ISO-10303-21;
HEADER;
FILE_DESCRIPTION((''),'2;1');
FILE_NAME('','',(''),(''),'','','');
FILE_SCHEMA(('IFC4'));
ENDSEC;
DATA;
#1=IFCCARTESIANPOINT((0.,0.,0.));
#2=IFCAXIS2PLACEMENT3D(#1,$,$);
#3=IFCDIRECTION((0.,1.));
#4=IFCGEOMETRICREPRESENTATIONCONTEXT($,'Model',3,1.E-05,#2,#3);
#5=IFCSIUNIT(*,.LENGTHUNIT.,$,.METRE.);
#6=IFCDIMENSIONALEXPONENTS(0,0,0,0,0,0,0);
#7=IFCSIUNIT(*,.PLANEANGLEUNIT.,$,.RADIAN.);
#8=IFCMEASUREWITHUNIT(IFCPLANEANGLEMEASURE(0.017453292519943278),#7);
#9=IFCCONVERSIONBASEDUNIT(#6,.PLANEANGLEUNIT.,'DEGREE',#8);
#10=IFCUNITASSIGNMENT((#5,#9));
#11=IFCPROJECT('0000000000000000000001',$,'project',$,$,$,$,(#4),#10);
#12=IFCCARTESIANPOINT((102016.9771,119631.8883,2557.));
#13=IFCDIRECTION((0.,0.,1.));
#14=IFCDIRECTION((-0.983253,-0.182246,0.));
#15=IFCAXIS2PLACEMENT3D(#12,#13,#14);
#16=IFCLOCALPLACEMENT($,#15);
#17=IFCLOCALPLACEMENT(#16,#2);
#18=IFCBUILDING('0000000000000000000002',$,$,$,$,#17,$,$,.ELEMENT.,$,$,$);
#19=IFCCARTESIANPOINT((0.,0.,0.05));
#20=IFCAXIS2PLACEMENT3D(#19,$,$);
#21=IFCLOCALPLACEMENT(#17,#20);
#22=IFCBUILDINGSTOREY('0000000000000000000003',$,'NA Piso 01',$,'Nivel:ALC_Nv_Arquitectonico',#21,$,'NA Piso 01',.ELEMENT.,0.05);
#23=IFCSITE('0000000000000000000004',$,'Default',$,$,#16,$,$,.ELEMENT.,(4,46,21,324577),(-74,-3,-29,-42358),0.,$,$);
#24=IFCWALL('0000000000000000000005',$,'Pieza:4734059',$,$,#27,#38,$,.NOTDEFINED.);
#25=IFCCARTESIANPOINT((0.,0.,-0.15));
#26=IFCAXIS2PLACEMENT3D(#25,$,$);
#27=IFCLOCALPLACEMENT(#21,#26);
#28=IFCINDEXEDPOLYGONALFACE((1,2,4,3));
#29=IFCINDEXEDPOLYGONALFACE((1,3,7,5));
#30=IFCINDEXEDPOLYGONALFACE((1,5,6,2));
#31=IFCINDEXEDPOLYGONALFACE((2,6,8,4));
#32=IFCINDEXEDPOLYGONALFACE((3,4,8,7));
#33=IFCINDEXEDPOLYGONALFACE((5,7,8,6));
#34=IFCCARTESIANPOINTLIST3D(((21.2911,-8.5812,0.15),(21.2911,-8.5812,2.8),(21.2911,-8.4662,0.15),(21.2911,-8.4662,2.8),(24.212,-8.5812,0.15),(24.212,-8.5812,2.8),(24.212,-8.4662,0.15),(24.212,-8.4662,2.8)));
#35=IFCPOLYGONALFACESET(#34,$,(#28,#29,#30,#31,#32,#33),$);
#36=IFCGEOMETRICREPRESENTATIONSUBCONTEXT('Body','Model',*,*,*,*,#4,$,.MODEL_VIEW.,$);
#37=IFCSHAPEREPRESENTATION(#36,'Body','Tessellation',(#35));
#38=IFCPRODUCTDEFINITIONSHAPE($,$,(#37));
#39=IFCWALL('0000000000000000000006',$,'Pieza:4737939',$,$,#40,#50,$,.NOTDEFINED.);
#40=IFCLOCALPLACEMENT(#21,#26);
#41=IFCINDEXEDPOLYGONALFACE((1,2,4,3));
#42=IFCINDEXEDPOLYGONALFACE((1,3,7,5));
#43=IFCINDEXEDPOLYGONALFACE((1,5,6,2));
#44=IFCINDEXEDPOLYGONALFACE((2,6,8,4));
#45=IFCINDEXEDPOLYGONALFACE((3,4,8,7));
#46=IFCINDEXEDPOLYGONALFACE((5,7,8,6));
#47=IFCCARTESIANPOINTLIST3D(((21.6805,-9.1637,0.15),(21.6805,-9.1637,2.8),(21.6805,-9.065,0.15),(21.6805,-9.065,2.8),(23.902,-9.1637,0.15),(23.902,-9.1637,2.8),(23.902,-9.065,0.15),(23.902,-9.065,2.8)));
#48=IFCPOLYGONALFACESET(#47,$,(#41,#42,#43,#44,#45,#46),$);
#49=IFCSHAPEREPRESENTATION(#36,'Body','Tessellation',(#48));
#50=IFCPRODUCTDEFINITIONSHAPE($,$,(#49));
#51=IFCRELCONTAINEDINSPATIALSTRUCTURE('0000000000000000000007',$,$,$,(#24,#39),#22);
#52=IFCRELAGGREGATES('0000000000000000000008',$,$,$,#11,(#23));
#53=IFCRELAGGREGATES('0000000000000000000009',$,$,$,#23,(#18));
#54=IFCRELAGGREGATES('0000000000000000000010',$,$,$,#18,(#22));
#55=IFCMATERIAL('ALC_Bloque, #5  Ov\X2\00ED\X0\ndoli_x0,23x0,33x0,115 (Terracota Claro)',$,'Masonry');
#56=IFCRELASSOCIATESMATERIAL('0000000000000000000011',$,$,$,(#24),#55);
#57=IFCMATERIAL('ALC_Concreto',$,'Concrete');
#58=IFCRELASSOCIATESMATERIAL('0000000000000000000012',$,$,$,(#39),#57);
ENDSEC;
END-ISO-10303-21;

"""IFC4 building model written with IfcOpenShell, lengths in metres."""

from ifc_helpers import new_model, entity, si_unit, converted_unit, direction, frame, frame_2d, origin, origin_2d_with_axis, place, context, subcontext, project, spatial, rectangle, extrude, material, element, save


model = new_model("IFC4")

# Units and contexts
model_context = context("Model", 3, precision=1e-05, world=origin(), true_north=direction((0.0, 1.0)))
body_context = subcontext(model_context, "Body", "Model", "MODEL_VIEW")
ifc_project = project(units=[si_unit("LENGTHUNIT", "METRE"), converted_unit("PLANEANGLEUNIT", "DEGREE", entity("IfcPlaneAngleMeasure", 0.017453292519943278), si_unit("PLANEANGLEUNIT", "RADIAN"), dimensions=[0, 0, 0, 0, 0, 0, 0])], contexts=[model_context])

# Site, building, storey
site_placement = place(None, frame((102016.9771, 119631.8883, 2557.0), z_axis=(0.0, 0.0, 1.0), x_axis=(-0.983253, -0.182246, 0.0)))
site = spatial("IfcSite", under=ifc_project, at=site_placement, Name="Default", CompositionType="ELEMENT", RefLatitude=(4, 46, 21, 324577), RefLongitude=(-74, -3, -29, -42358), RefElevation=0.0)
building_placement = place(site_placement, origin())
building = spatial("IfcBuilding", under=site, at=building_placement, CompositionType="ELEMENT")
storey_placement = place(building_placement, frame((0.0, 0.0, 0.05)))
storey = spatial("IfcBuildingStorey", under=building, at=storey_placement, Name="NA Piso 01", ObjectType="Nivel:ALC_Nv_Arquitectonico", LongName="NA Piso 01", CompositionType="ELEMENT", Elevation=0.05)

# Walls
ifc_material_1 = material(Name="ALC_Bloque, #5  Ovíndoli_x0,23x0,33x0,115 (Terracota Claro)", Category="Masonry")
wall_1_placement = place(storey_placement, frame((0.0, 0.0, -0.15)))
element("IfcWall", 1, at=wall_1_placement, inside=storey, material=ifc_material_1, Name="Pieza:4734059", PredefinedType="NOTDEFINED", context=body_context, shape_type="SweptSolid", body=[
    extrude(rectangle(XDim=0.115, YDim=2.9209, at=frame_2d((0.0, 0.0), x_axis=(1.0, 0.0))), frame((22.7516, -8.5237, 0.15), z_axis=(0.0, 0.0, 1.0), x_axis=(0.0, -1.0, 0.0)), (0.0, 0.0, 1.0), 2.65),
])
ifc_material_2 = material(Name="ALC_Concreto", Category="Concrete")
wall_2_placement = place(storey_placement, frame((0.0, 0.0, -0.15)))
element("IfcWall", 2, at=wall_2_placement, inside=storey, material=ifc_material_2, Name="Pieza:4737939", PredefinedType="NOTDEFINED", context=body_context, shape_type="SweptSolid", body=[
    extrude(rectangle(XDim=0.0987, YDim=2.2215, at=origin_2d_with_axis()), frame((22.7913, -9.1143, 0.15), z_axis=(0.0, 0.0, 1.0), x_axis=(0.0, -1.0, 0.0)), (0.0, 0.0, 1.0), 2.65),
])

save(model, "model.ifc")
